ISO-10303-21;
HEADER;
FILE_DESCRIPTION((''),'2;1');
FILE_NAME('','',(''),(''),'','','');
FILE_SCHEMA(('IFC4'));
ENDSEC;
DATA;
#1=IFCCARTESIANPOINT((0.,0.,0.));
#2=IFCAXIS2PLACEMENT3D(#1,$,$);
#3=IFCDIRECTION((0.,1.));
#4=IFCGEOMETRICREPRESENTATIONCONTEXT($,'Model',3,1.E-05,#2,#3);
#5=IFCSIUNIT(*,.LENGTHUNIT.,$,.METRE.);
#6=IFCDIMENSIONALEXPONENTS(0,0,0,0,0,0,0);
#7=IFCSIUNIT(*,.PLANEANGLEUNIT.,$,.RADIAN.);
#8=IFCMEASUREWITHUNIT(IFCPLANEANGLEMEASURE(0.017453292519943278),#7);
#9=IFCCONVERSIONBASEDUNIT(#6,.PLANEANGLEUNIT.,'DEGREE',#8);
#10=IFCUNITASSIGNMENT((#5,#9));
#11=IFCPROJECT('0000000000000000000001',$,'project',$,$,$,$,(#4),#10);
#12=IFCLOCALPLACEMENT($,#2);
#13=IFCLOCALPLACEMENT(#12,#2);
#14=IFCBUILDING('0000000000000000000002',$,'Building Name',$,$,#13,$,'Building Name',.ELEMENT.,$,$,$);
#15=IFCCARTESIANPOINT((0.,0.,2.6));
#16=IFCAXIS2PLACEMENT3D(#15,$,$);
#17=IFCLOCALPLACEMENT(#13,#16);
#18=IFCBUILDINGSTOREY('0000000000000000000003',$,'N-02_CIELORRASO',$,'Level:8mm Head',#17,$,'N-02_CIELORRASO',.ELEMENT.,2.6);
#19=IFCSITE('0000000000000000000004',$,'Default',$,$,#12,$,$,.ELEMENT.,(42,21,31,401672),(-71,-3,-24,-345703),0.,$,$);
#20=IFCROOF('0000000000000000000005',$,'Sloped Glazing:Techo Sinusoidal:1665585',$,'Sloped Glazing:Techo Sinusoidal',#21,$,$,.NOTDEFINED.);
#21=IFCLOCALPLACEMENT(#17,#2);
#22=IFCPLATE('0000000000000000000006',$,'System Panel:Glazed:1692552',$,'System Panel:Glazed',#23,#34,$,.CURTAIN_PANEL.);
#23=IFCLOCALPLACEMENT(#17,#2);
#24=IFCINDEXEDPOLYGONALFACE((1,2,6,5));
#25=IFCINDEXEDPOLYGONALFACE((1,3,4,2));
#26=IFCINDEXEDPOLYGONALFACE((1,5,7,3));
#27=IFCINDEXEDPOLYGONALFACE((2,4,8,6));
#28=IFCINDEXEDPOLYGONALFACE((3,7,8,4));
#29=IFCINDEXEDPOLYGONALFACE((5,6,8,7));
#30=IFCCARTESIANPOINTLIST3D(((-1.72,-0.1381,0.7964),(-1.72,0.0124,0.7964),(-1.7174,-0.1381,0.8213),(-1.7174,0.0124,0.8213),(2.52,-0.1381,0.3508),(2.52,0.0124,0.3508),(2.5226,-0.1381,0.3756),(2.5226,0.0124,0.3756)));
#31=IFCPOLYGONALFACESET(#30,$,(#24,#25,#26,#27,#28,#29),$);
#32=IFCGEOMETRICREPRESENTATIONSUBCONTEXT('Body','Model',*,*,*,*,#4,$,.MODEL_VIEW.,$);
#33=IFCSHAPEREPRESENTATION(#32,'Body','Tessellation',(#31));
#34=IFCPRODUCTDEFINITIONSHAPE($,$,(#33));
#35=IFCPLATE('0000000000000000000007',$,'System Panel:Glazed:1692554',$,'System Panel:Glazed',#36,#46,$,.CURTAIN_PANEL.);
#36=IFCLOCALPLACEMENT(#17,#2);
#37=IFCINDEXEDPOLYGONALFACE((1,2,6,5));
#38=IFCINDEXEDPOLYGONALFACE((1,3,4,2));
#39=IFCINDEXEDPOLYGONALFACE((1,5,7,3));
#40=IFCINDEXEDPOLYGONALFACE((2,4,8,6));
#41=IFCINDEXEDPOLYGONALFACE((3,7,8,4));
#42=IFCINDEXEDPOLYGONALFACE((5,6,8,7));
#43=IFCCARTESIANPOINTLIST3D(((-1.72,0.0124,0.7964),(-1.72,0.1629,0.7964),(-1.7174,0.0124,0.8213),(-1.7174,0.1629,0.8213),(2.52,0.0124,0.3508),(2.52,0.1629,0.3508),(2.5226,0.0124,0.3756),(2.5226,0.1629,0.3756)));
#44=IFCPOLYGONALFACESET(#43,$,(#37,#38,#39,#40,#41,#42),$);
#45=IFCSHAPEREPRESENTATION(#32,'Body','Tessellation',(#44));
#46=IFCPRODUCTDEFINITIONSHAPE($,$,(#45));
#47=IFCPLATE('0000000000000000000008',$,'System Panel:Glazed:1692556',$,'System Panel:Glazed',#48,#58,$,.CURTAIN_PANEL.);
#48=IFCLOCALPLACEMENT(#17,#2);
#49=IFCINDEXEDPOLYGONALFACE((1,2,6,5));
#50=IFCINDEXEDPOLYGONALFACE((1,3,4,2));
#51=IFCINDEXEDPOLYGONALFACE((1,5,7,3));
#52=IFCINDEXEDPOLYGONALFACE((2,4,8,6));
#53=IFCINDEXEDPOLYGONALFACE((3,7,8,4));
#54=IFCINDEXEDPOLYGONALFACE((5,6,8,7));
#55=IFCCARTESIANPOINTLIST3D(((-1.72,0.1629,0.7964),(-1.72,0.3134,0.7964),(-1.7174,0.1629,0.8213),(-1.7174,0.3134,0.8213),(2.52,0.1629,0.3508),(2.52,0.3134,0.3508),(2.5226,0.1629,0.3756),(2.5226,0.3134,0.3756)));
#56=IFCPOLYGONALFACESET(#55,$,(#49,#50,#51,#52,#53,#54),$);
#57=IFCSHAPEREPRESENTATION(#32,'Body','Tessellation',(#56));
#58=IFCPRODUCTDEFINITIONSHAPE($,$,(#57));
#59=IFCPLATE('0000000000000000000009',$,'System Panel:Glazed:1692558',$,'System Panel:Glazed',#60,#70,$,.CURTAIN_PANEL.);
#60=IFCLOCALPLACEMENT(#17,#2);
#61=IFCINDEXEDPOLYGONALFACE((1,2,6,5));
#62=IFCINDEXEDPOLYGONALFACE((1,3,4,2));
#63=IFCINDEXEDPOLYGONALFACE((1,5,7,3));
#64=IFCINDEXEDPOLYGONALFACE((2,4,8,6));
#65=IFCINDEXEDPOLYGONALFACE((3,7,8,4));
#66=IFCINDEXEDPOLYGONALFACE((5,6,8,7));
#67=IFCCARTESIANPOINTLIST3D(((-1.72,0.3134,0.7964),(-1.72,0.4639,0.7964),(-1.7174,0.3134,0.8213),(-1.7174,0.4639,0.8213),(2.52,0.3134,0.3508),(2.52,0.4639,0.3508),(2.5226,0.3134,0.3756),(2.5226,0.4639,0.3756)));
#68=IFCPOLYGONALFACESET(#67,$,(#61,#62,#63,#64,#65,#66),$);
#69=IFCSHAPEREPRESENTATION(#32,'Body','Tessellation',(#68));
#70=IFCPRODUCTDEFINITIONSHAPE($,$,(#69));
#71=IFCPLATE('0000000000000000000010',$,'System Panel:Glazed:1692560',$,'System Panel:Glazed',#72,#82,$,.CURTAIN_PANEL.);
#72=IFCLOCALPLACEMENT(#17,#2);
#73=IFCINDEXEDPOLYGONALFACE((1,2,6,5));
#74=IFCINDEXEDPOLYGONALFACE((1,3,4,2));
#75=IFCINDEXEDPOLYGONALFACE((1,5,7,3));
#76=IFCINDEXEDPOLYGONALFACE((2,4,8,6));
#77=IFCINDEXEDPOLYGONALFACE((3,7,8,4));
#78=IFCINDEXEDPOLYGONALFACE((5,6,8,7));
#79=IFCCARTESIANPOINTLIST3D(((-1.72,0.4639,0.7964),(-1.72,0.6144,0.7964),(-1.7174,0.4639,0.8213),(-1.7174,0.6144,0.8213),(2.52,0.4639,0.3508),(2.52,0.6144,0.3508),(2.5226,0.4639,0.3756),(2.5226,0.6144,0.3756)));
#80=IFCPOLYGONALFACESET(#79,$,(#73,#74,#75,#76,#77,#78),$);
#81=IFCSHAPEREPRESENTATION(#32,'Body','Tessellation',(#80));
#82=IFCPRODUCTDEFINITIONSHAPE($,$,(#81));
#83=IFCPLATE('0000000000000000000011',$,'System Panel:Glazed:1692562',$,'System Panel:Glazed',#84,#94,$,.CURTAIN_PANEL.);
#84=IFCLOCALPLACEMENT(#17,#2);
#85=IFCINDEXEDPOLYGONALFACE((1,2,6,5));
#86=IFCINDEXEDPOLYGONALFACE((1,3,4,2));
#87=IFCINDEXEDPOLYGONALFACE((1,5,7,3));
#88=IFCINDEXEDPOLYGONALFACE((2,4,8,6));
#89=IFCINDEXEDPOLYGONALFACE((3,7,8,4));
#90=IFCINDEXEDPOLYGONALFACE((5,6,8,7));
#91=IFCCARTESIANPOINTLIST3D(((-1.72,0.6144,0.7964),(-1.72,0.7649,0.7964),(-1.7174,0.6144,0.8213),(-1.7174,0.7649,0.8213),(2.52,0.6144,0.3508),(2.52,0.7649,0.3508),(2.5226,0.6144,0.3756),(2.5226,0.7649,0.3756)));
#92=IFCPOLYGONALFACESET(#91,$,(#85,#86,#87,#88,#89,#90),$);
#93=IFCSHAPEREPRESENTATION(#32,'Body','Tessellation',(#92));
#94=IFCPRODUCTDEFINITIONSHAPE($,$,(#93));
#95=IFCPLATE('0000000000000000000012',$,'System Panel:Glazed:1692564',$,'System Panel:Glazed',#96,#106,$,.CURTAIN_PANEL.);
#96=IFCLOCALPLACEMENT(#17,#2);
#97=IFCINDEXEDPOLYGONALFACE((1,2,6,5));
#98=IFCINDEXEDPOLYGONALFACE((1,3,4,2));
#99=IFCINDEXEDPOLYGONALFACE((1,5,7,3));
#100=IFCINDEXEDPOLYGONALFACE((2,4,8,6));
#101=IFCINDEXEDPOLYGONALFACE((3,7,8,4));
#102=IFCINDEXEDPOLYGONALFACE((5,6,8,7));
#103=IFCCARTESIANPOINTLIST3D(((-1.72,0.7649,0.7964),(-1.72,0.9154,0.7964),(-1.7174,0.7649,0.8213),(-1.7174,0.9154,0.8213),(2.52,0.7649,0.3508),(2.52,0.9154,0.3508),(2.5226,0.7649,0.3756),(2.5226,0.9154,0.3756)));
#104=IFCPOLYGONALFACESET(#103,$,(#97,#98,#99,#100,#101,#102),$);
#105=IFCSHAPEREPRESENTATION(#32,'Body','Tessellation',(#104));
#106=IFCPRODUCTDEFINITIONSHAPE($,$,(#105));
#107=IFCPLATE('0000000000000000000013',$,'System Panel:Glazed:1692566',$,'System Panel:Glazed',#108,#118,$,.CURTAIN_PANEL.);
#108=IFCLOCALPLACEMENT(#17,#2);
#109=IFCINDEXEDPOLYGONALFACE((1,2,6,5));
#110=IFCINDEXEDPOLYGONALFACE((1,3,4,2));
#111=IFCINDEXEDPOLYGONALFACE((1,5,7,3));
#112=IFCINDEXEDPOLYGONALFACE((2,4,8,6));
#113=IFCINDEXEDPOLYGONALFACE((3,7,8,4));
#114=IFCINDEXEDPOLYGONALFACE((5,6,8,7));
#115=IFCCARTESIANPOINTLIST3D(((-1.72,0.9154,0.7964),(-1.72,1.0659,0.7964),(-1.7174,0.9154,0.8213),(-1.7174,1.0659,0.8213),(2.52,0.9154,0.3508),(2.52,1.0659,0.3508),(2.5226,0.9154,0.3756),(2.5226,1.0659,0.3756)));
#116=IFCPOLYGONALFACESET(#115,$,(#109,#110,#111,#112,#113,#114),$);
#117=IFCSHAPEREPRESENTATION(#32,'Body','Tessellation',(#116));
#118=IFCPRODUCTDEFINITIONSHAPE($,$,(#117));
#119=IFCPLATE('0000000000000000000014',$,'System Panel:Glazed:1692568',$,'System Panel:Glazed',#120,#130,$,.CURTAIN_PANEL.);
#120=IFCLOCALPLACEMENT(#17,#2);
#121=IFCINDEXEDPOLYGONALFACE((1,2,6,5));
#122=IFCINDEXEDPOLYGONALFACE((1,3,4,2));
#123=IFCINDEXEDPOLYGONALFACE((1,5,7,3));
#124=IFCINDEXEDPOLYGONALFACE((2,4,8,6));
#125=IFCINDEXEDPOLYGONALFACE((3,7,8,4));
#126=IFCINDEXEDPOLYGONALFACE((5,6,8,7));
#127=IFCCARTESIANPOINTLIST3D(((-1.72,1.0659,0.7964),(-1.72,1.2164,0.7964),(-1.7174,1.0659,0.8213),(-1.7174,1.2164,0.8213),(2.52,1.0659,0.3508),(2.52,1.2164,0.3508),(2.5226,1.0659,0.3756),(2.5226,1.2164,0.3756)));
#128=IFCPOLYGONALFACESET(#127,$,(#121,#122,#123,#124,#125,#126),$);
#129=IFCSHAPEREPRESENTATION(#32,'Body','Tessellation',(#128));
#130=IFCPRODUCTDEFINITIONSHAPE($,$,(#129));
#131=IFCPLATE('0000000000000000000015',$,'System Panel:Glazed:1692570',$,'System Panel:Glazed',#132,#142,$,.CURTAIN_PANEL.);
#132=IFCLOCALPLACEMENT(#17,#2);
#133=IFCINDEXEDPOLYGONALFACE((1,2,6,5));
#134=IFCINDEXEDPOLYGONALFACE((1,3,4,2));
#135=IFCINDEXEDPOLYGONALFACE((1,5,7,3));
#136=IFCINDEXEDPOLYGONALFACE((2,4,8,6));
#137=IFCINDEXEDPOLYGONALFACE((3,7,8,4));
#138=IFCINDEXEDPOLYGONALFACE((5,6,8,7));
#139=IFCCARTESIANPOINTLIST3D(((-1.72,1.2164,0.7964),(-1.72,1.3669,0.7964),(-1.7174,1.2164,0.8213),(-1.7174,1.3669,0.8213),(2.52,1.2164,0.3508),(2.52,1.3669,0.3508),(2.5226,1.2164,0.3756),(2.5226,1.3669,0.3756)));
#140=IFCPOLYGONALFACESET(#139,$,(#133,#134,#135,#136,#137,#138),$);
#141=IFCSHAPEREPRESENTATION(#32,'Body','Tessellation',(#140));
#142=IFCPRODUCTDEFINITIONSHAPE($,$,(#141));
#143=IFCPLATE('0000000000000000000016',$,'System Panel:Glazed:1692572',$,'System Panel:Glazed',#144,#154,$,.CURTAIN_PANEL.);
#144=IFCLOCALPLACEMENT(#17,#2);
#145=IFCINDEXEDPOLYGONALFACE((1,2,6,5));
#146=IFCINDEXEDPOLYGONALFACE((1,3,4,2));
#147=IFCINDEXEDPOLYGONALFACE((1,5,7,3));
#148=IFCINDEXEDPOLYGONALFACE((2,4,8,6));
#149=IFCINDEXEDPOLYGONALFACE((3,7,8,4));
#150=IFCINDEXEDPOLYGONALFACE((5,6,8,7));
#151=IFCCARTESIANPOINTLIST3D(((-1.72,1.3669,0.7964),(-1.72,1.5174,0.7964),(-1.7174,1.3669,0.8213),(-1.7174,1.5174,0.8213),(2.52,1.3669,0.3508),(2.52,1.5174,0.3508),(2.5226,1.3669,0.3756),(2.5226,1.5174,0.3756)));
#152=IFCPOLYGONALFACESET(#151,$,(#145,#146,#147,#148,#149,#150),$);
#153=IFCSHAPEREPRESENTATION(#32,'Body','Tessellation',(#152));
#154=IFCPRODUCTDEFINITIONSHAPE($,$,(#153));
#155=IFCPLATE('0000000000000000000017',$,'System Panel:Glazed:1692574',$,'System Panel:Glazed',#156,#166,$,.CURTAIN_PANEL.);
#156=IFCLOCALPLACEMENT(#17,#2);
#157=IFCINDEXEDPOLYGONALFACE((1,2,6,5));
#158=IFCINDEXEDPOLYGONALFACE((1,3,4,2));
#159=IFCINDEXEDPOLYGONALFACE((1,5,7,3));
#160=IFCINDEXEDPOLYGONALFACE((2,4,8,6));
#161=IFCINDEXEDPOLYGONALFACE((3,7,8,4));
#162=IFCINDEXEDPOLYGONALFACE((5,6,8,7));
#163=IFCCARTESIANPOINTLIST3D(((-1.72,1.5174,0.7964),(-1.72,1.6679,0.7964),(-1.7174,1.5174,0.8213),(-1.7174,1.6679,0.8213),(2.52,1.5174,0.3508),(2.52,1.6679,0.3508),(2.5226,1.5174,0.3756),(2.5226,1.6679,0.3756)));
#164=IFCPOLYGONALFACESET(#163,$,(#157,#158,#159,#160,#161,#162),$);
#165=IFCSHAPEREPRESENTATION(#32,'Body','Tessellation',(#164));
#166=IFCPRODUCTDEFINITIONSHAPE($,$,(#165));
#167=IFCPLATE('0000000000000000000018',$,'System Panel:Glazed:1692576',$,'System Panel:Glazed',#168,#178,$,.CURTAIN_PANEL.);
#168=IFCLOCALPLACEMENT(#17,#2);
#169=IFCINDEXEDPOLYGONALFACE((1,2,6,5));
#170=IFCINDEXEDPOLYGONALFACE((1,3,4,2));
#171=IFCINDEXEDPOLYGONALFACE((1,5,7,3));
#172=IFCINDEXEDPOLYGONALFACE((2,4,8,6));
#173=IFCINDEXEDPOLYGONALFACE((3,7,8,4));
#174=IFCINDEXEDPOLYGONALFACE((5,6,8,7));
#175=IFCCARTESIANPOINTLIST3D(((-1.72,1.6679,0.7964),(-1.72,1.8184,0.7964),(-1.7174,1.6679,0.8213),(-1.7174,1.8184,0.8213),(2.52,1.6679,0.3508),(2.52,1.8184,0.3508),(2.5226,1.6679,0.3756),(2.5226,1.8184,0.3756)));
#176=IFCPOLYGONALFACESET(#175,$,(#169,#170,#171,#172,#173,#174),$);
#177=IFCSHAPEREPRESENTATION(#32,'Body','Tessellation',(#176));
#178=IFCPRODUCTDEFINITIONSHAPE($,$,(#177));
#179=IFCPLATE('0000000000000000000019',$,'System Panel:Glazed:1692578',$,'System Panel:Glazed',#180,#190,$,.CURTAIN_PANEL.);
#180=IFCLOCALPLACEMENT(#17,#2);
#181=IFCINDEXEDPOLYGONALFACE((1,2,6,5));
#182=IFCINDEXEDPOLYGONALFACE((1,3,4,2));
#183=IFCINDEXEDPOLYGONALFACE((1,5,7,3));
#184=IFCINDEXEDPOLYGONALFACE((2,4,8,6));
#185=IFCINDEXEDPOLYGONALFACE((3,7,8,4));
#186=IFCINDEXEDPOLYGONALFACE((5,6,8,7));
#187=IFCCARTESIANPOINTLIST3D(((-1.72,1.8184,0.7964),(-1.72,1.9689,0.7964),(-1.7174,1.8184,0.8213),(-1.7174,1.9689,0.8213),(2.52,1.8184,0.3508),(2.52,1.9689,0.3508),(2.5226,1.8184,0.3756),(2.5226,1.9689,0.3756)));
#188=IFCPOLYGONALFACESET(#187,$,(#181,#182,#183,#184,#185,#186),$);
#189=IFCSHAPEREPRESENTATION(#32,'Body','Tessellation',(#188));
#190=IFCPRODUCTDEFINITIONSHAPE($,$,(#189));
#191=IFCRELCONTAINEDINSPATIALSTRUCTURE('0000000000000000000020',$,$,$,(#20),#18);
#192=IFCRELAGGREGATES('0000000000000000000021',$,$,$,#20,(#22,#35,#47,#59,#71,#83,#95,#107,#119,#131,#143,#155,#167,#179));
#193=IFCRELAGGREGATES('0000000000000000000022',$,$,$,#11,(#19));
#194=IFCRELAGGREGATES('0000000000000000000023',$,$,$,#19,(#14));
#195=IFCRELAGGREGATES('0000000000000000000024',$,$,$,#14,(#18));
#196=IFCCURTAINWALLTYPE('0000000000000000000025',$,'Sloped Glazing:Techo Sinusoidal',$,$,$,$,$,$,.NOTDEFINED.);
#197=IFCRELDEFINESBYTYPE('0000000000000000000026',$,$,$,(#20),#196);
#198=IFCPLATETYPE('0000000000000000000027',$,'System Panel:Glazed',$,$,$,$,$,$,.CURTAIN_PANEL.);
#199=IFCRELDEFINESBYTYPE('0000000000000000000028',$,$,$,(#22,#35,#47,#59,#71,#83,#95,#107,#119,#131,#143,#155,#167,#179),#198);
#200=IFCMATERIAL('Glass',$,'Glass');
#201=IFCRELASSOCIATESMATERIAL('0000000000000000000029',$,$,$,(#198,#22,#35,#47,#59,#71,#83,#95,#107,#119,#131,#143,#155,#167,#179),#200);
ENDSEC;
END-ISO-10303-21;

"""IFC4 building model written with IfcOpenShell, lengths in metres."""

from ifc_helpers import new_model, entity, si_unit, converted_unit, direction, frame, origin, place, context, subcontext, project, spatial, indexed_curve, outline, extrude, source, transform, mapped, material, type_object, type_shapes, element, aggregate, save


model = new_model("IFC4")

# Units and contexts
model_context = context("Model", 3, precision=1e-05, world=origin(), true_north=direction((0.0, 1.0)))
body_context = subcontext(model_context, "Body", "Model", "MODEL_VIEW")
ifc_project = project(units=[si_unit("LENGTHUNIT", "METRE"), converted_unit("PLANEANGLEUNIT", "DEGREE", entity("IfcPlaneAngleMeasure", 0.017453292519943278), si_unit("PLANEANGLEUNIT", "RADIAN"), dimensions=[0, 0, 0, 0, 0, 0, 0])], contexts=[model_context])

# Site, building, storey
site_placement = place(None, origin())
site = spatial("IfcSite", under=ifc_project, at=site_placement, Name="Default", CompositionType="ELEMENT", RefLatitude=(42, 21, 31, 401672), RefLongitude=(-71, -3, -24, -345703), RefElevation=0.0)
building_placement = place(site_placement, origin())
building = spatial("IfcBuilding", under=site, at=building_placement, Name="Building Name", LongName="Building Name", CompositionType="ELEMENT")
storey_placement = place(building_placement, frame((0.0, 0.0, 2.6)))
storey = spatial("IfcBuildingStorey", under=building, at=storey_placement, Name="N-02_CIELORRASO", ObjectType="Level:8mm Head", LongName="N-02_CIELORRASO", CompositionType="ELEMENT", Elevation=2.6)

# Roof, plates
curtain_wall_type = type_object("IfcCurtainWallType", Name="Sloped Glazing:Techo Sinusoidal", PredefinedType="NOTDEFINED")
roof_placement = place(storey_placement, frame((0.0, 0.0, -2.6)))
roof = element("IfcRoof", 1, at=roof_placement, inside=storey, type_object=curtain_wall_type, Name="Sloped Glazing:Techo Sinusoidal:1665585", ObjectType="Sloped Glazing:Techo Sinusoidal", PredefinedType="NOTDEFINED")
ifc_material_1 = material(Name="Glass", Category="Glass")
plate_type = type_object("IfcPlateType", Name="System Panel:Glazed", PredefinedType="CURTAIN_PANEL", material=ifc_material_1)
shared_shape_1 = source(origin(), body_context, "Body", "SweptSolid", [
    extrude(outline(indexed_curve([(-0.0125, -0.0752), (0.0125, -0.0752), (0.0125, 0.0752), (-0.0125, 0.0752), (-0.0125, -0.0752)], self_intersect=False)), frame((0.0, 0.037, 0.0), z_axis=(0.0, 0.0, 1.0), x_axis=(0.0, 1.0, 0.0)), (0.0, 0.0, 1.0), 4.2634),
])
type_shapes(plate_type, [shared_shape_1])
plate_1_placement = place(roof_placement, frame((2.5252, -0.0629, 3.0), z_axis=(-0.994522, 0.0, 0.104528), x_axis=(0.0, 1.0, 0.0)))
plate_1 = element("IfcPlate", 2, at=plate_1_placement, type_object=plate_type, material=ifc_material_1, Name="System Panel:Glazed:1692552", ObjectType="System Panel:Glazed", PredefinedType="CURTAIN_PANEL", context=body_context, shape_type="MappedRepresentation", body=[
    mapped(shared_shape_1, transform((0.0, 0.0, 0.0), scale=1.0)),
])
plate_2_placement = place(roof_placement, frame((2.5252, 0.0876, 3.0), z_axis=(-0.994522, 0.0, 0.104528), x_axis=(0.0, 1.0, 0.0)))
plate_2 = element("IfcPlate", 3, at=plate_2_placement, type_object=plate_type, material=ifc_material_1, Name="System Panel:Glazed:1692554", ObjectType="System Panel:Glazed", PredefinedType="CURTAIN_PANEL", context=body_context, shape_type="MappedRepresentation", body=[
    mapped(shared_shape_1, transform((0.0, 0.0, 0.0), scale=1.0)),
])
plate_3_placement = place(roof_placement, frame((2.5252, 0.2381, 3.0), z_axis=(-0.994522, 0.0, 0.104528), x_axis=(0.0, 1.0, 0.0)))
plate_3 = element("IfcPlate", 4, at=plate_3_placement, type_object=plate_type, material=ifc_material_1, Name="System Panel:Glazed:1692556", ObjectType="System Panel:Glazed", PredefinedType="CURTAIN_PANEL", context=body_context, shape_type="MappedRepresentation", body=[
    mapped(shared_shape_1, transform((0.0, 0.0, 0.0), scale=1.0)),
])
plate_4_placement = place(roof_placement, frame((2.5252, 0.3886, 3.0), z_axis=(-0.994522, 0.0, 0.104528), x_axis=(0.0, 1.0, 0.0)))
plate_4 = element("IfcPlate", 5, at=plate_4_placement, type_object=plate_type, material=ifc_material_1, Name="System Panel:Glazed:1692558", ObjectType="System Panel:Glazed", PredefinedType="CURTAIN_PANEL", context=body_context, shape_type="MappedRepresentation", body=[
    mapped(shared_shape_1, transform((0.0, 0.0, 0.0), scale=1.0)),
])
plate_5_placement = place(roof_placement, frame((2.5252, 0.5391, 3.0), z_axis=(-0.994522, 0.0, 0.104528), x_axis=(0.0, 1.0, 0.0)))
plate_5 = element("IfcPlate", 6, at=plate_5_placement, type_object=plate_type, material=ifc_material_1, Name="System Panel:Glazed:1692560", ObjectType="System Panel:Glazed", PredefinedType="CURTAIN_PANEL", context=body_context, shape_type="MappedRepresentation", body=[
    mapped(shared_shape_1, transform((0.0, 0.0, 0.0), scale=1.0)),
])
plate_6_placement = place(roof_placement, frame((2.5252, 0.6896, 3.0), z_axis=(-0.994522, 0.0, 0.104528), x_axis=(0.0, 1.0, 0.0)))
plate_6 = element("IfcPlate", 7, at=plate_6_placement, type_object=plate_type, material=ifc_material_1, Name="System Panel:Glazed:1692562", ObjectType="System Panel:Glazed", PredefinedType="CURTAIN_PANEL", context=body_context, shape_type="MappedRepresentation", body=[
    mapped(shared_shape_1, transform((0.0, 0.0, 0.0), scale=1.0)),
])
plate_7_placement = place(roof_placement, frame((2.5252, 0.8401, 3.0), z_axis=(-0.994522, 0.0, 0.104528), x_axis=(0.0, 1.0, 0.0)))
plate_7 = element("IfcPlate", 8, at=plate_7_placement, type_object=plate_type, material=ifc_material_1, Name="System Panel:Glazed:1692564", ObjectType="System Panel:Glazed", PredefinedType="CURTAIN_PANEL", context=body_context, shape_type="MappedRepresentation", body=[
    mapped(shared_shape_1, transform((0.0, 0.0, 0.0), scale=1.0)),
])
plate_8_placement = place(roof_placement, frame((2.5252, 0.9906, 3.0), z_axis=(-0.994522, 0.0, 0.104528), x_axis=(0.0, 1.0, 0.0)))
plate_8 = element("IfcPlate", 9, at=plate_8_placement, type_object=plate_type, material=ifc_material_1, Name="System Panel:Glazed:1692566", ObjectType="System Panel:Glazed", PredefinedType="CURTAIN_PANEL", context=body_context, shape_type="MappedRepresentation", body=[
    mapped(shared_shape_1, transform((0.0, 0.0, 0.0), scale=1.0)),
])
plate_9_placement = place(roof_placement, frame((2.5252, 1.1411, 3.0), z_axis=(-0.994522, 0.0, 0.104528), x_axis=(0.0, 1.0, 0.0)))
plate_9 = element("IfcPlate", 10, at=plate_9_placement, type_object=plate_type, material=ifc_material_1, Name="System Panel:Glazed:1692568", ObjectType="System Panel:Glazed", PredefinedType="CURTAIN_PANEL", context=body_context, shape_type="MappedRepresentation", body=[
    mapped(shared_shape_1, transform((0.0, 0.0, 0.0), scale=1.0)),
])
plate_10_placement = place(roof_placement, frame((2.5252, 1.2916, 3.0), z_axis=(-0.994522, 0.0, 0.104528), x_axis=(0.0, 1.0, 0.0)))
plate_10 = element("IfcPlate", 11, at=plate_10_placement, type_object=plate_type, material=ifc_material_1, Name="System Panel:Glazed:1692570", ObjectType="System Panel:Glazed", PredefinedType="CURTAIN_PANEL", context=body_context, shape_type="MappedRepresentation", body=[
    mapped(shared_shape_1, transform((0.0, 0.0, 0.0), scale=1.0)),
])
plate_11_placement = place(roof_placement, frame((2.5252, 1.4421, 3.0), z_axis=(-0.994522, 0.0, 0.104528), x_axis=(0.0, 1.0, 0.0)))
plate_11 = element("IfcPlate", 12, at=plate_11_placement, type_object=plate_type, material=ifc_material_1, Name="System Panel:Glazed:1692572", ObjectType="System Panel:Glazed", PredefinedType="CURTAIN_PANEL", context=body_context, shape_type="MappedRepresentation", body=[
    mapped(shared_shape_1, transform((0.0, 0.0, 0.0), scale=1.0)),
])
plate_12_placement = place(roof_placement, frame((2.5252, 1.5926, 3.0), z_axis=(-0.994522, 0.0, 0.104528), x_axis=(0.0, 1.0, 0.0)))
plate_12 = element("IfcPlate", 13, at=plate_12_placement, type_object=plate_type, material=ifc_material_1, Name="System Panel:Glazed:1692574", ObjectType="System Panel:Glazed", PredefinedType="CURTAIN_PANEL", context=body_context, shape_type="MappedRepresentation", body=[
    mapped(shared_shape_1, transform((0.0, 0.0, 0.0), scale=1.0)),
])
plate_13_placement = place(roof_placement, frame((2.5252, 1.7431, 3.0), z_axis=(-0.994522, 0.0, 0.104528), x_axis=(0.0, 1.0, 0.0)))
plate_13 = element("IfcPlate", 14, at=plate_13_placement, type_object=plate_type, material=ifc_material_1, Name="System Panel:Glazed:1692576", ObjectType="System Panel:Glazed", PredefinedType="CURTAIN_PANEL", context=body_context, shape_type="MappedRepresentation", body=[
    mapped(shared_shape_1, transform((0.0, 0.0, 0.0), scale=1.0)),
])
plate_14_placement = place(roof_placement, frame((2.5252, 1.8936, 3.0), z_axis=(-0.994522, 0.0, 0.104528), x_axis=(0.0, 1.0, 0.0)))
plate_14 = element("IfcPlate", 15, at=plate_14_placement, type_object=plate_type, material=ifc_material_1, Name="System Panel:Glazed:1692578", ObjectType="System Panel:Glazed", PredefinedType="CURTAIN_PANEL", context=body_context, shape_type="MappedRepresentation", body=[
    mapped(shared_shape_1, transform((0.0, 0.0, 0.0), scale=1.0)),
])
aggregate(roof, [plate_1, plate_2, plate_3, plate_4, plate_5, plate_6, plate_7, plate_8, plate_9, plate_10, plate_11, plate_12, plate_13, plate_14])

save(model, "model.ifc")
